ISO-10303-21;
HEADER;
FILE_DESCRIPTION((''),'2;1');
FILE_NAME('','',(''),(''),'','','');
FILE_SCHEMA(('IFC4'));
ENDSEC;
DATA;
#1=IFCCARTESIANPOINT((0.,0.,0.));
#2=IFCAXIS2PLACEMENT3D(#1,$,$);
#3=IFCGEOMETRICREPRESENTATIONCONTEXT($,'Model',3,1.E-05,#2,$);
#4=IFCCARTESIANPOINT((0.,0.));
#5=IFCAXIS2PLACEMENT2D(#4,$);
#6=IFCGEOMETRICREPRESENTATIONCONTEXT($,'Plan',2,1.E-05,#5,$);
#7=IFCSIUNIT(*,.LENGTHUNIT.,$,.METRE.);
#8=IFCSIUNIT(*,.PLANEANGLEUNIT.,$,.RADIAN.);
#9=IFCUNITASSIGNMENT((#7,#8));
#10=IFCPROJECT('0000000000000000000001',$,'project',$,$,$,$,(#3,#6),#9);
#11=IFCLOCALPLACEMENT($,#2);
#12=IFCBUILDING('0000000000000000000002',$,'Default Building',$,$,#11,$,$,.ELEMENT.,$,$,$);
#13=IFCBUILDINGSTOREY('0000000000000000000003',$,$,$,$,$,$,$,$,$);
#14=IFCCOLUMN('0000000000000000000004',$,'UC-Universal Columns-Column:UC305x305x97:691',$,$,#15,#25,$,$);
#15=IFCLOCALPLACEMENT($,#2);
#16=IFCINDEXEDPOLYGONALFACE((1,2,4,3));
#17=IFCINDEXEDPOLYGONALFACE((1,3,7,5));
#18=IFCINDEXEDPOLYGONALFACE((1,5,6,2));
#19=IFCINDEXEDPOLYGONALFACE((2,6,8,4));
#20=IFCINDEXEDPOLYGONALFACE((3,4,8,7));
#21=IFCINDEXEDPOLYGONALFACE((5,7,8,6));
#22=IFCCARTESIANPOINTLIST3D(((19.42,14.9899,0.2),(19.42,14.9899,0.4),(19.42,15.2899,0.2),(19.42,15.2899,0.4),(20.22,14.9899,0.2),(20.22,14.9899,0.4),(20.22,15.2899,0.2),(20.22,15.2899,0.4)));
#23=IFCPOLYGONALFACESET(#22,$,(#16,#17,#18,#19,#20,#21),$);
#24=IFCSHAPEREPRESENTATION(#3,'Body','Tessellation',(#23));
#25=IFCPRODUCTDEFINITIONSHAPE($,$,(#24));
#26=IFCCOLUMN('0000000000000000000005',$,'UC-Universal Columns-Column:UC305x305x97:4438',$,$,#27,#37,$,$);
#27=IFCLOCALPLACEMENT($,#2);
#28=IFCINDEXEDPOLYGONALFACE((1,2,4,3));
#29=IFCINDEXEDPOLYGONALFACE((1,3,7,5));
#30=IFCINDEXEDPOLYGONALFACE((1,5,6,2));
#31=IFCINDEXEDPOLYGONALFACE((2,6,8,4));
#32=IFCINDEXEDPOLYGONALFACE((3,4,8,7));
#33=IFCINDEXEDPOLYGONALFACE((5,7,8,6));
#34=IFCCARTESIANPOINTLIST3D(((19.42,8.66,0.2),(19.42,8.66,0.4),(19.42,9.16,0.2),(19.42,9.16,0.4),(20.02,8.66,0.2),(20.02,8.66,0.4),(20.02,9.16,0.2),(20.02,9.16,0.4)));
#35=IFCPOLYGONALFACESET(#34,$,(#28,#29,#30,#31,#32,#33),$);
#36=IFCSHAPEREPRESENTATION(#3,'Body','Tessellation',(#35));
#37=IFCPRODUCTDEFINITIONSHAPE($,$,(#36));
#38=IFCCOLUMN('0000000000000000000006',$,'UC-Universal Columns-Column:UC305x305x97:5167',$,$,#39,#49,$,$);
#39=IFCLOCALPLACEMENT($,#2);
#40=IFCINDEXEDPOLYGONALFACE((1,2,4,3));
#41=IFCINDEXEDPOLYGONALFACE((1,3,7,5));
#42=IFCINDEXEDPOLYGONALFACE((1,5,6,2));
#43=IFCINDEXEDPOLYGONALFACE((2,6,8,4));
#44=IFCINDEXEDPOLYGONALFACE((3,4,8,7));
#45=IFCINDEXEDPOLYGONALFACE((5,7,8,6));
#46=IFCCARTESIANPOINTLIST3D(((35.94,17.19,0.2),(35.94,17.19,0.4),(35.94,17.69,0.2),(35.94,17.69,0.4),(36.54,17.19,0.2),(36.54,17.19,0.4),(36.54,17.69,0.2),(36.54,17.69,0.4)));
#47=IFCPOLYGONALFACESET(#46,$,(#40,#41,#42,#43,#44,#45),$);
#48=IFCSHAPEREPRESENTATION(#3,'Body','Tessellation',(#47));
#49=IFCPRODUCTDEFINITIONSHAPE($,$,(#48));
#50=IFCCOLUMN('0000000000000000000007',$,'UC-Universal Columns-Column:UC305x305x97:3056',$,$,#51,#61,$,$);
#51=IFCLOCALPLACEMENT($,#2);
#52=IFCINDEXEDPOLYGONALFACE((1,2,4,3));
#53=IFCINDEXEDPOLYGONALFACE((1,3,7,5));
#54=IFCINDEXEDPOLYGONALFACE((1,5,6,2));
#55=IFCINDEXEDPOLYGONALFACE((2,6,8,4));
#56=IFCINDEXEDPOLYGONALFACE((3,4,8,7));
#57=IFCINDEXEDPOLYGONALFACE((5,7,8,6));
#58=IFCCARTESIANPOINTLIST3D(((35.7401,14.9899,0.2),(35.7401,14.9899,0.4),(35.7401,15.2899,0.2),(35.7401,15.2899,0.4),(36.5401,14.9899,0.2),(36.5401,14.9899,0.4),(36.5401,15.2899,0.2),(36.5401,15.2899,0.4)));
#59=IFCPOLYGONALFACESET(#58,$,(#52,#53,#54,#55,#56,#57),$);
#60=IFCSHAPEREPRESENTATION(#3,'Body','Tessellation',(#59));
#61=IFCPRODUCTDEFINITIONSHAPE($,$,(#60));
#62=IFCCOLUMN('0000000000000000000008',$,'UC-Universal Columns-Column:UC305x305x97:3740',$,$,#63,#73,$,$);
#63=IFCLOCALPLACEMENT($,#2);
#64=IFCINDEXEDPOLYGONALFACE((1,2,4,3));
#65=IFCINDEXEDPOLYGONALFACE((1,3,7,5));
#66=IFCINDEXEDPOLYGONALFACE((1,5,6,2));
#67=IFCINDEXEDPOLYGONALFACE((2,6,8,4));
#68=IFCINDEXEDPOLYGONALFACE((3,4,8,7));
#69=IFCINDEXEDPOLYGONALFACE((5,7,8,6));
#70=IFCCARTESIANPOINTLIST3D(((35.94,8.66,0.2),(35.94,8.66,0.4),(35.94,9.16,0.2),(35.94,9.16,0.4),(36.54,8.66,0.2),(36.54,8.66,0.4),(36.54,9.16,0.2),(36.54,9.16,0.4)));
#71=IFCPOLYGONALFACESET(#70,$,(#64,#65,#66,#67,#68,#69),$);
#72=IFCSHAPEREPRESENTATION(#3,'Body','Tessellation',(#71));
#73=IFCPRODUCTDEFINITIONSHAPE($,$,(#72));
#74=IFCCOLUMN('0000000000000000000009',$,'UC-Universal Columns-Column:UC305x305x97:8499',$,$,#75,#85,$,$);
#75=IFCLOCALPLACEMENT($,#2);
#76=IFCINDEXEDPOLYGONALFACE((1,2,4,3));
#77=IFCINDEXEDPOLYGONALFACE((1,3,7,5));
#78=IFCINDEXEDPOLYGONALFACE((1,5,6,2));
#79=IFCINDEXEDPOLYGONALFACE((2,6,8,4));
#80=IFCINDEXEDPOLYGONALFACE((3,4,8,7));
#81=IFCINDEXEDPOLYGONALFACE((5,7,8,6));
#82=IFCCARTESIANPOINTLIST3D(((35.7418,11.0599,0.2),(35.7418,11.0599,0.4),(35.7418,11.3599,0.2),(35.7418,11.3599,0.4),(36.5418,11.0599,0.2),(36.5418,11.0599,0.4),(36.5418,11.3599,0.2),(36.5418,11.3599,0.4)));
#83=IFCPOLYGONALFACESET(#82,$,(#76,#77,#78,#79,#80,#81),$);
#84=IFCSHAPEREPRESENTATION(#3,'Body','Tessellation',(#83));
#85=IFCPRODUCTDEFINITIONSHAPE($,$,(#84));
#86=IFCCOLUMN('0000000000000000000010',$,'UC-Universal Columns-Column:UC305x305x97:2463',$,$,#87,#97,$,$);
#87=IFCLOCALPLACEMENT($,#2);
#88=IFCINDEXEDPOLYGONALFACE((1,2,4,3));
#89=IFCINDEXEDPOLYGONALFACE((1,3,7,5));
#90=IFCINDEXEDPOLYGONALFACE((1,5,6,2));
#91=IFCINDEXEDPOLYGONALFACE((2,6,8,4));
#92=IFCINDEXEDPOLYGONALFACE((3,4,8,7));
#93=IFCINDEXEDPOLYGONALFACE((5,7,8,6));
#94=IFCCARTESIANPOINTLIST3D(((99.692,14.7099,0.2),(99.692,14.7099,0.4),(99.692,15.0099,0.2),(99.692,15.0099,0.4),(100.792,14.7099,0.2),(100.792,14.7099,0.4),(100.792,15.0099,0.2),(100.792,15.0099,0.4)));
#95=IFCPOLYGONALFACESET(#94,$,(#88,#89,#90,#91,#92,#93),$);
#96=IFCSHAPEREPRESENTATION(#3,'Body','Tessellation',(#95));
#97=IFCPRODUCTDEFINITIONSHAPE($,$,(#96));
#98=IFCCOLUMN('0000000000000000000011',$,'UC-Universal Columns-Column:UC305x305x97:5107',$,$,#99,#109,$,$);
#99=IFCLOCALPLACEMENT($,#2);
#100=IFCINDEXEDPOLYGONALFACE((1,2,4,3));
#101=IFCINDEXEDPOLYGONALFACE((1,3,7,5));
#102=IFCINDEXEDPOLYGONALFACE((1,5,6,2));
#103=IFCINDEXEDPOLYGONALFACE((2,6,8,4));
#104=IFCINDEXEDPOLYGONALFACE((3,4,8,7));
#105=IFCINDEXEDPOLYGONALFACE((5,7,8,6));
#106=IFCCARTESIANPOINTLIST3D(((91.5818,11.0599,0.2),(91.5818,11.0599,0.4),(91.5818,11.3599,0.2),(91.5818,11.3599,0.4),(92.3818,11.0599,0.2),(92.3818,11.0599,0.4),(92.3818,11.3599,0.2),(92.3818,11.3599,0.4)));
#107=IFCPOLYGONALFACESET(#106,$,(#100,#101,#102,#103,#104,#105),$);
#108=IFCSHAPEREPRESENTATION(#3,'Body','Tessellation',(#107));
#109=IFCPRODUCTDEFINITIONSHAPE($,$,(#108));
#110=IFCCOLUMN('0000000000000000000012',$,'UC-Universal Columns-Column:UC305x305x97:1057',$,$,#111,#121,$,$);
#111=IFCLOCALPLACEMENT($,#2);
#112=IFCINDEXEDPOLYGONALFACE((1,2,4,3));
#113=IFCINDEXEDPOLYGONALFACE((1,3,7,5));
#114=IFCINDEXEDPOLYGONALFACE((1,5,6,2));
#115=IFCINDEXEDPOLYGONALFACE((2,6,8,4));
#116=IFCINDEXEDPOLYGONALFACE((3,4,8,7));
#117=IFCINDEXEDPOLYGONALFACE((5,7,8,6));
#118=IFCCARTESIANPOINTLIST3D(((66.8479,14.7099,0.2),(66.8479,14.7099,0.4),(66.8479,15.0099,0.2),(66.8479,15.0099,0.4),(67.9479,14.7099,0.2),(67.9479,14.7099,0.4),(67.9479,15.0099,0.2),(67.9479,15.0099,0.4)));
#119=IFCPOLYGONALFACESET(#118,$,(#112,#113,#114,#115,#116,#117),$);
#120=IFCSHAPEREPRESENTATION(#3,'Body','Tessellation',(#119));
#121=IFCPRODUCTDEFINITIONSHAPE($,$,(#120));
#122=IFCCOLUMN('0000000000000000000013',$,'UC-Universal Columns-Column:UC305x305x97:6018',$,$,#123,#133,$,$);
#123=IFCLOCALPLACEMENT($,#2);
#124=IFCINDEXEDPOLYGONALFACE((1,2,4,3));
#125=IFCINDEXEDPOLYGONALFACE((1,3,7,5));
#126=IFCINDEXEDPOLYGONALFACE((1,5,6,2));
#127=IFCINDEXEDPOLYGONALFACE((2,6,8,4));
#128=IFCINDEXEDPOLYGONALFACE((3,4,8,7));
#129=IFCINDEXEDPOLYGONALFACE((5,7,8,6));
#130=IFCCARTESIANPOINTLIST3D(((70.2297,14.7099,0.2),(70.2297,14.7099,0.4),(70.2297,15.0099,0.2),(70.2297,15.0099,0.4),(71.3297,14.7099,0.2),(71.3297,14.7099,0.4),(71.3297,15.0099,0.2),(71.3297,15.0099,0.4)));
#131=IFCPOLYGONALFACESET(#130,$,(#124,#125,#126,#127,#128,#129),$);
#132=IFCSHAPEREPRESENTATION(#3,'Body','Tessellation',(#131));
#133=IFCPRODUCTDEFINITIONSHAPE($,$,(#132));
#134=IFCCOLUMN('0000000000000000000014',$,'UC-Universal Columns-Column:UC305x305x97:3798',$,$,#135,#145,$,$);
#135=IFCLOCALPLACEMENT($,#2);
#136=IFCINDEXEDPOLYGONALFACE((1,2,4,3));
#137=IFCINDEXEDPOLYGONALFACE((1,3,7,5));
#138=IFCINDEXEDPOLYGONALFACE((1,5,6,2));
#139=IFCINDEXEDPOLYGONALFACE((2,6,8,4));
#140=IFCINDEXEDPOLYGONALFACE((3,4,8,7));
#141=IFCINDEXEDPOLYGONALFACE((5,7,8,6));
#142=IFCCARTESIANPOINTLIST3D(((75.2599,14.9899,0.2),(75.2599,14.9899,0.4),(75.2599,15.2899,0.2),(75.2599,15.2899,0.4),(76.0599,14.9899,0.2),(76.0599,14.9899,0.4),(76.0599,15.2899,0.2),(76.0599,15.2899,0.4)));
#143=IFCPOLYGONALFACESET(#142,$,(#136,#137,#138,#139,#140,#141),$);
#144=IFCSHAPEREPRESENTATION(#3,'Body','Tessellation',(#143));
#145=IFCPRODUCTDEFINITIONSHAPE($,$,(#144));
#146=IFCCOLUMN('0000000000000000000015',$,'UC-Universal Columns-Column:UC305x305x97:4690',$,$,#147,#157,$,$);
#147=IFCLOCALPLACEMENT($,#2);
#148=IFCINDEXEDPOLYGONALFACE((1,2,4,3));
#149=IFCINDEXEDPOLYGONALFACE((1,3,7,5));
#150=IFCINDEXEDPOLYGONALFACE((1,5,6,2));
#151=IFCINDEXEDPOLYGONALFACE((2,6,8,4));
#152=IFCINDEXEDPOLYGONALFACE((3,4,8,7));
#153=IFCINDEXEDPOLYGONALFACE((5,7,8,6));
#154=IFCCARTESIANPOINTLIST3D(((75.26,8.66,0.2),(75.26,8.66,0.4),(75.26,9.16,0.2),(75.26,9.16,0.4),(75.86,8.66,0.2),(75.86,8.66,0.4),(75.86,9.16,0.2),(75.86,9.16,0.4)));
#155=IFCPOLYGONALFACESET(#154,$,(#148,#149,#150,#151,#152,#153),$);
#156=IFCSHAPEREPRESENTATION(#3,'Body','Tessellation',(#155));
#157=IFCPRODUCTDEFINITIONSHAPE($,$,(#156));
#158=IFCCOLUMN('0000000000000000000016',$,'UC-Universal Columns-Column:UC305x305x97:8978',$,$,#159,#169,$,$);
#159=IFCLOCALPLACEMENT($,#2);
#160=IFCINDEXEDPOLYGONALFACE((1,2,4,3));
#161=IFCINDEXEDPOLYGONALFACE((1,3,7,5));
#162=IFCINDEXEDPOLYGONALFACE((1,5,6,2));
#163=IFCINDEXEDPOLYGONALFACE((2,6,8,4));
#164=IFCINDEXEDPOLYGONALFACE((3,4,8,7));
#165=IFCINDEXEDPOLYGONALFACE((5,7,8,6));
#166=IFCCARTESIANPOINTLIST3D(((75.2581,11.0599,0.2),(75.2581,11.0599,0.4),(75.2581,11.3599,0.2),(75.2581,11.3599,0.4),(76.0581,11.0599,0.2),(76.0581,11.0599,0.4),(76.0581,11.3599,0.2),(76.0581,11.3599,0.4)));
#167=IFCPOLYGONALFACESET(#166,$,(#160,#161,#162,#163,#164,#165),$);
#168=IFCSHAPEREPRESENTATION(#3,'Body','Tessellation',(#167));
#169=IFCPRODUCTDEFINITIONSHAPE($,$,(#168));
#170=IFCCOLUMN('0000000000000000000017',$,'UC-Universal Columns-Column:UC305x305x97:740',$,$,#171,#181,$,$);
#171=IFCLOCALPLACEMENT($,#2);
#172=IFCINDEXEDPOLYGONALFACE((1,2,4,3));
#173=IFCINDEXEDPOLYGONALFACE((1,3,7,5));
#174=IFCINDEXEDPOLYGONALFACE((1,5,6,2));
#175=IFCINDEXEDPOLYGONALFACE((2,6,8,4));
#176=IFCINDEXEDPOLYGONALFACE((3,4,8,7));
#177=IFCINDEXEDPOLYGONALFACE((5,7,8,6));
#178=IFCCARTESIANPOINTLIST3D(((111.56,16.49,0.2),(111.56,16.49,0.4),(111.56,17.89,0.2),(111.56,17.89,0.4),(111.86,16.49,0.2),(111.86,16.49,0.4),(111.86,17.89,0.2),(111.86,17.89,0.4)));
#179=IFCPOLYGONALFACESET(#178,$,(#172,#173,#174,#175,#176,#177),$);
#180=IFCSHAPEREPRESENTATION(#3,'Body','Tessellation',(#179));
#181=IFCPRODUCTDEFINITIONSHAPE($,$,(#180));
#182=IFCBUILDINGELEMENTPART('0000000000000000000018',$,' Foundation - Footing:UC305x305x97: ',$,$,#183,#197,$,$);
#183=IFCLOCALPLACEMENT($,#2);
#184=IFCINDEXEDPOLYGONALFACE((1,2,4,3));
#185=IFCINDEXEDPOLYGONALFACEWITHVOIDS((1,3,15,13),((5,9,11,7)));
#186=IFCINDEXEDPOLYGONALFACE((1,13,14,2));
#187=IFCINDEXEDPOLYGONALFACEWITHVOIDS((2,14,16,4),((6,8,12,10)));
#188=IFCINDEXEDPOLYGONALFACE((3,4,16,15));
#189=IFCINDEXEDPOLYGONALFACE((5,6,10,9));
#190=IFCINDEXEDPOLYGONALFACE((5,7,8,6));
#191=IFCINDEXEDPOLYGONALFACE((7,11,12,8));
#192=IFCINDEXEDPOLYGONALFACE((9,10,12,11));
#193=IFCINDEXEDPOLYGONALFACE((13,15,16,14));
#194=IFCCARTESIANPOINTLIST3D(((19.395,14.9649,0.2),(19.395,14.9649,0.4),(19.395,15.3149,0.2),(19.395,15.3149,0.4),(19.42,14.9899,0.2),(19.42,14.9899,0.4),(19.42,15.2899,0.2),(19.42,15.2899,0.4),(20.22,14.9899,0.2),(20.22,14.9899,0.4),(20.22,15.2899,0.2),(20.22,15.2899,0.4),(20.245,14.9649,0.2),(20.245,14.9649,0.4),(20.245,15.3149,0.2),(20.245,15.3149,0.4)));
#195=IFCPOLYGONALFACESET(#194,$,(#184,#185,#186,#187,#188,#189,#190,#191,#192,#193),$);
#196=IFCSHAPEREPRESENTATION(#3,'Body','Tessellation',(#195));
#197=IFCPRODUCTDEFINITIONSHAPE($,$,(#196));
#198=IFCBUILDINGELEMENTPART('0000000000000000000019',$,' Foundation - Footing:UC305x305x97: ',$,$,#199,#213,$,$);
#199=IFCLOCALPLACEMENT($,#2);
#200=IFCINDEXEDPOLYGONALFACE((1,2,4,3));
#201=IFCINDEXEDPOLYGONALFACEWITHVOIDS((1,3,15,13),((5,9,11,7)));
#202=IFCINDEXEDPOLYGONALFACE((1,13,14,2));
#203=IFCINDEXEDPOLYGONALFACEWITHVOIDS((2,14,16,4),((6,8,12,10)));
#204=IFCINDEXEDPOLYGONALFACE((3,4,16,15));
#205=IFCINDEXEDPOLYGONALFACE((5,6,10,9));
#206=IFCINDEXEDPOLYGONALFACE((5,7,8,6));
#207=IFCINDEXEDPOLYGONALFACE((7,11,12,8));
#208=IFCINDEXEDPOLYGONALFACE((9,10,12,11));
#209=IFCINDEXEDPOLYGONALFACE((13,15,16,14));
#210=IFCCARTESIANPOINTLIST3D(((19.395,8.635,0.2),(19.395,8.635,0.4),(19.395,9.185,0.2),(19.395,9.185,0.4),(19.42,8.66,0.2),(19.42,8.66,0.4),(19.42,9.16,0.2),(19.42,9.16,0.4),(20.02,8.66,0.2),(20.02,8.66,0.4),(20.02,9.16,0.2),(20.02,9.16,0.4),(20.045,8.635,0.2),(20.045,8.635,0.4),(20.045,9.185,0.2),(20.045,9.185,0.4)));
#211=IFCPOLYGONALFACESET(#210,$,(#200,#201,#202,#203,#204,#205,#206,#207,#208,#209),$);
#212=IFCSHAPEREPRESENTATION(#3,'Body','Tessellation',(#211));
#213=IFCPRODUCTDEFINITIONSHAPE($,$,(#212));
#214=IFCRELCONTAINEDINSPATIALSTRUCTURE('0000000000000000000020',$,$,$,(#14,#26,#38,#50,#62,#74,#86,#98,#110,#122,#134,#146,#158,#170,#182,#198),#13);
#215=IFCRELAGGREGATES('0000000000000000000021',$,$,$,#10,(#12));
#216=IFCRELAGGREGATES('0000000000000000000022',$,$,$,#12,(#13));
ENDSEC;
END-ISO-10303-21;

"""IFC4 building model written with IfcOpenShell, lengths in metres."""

from ifc_helpers import new_model, si_unit, origin, origin_2d, place, context, project, spatial, polyline, outline, extrude, element, save


model = new_model("IFC4")

# Units and contexts
model_context = context("Model", 3, precision=1e-05, world=origin())
plan_context = context("Plan", 2, precision=1e-05, world=origin_2d())
ifc_project = project(units=[si_unit("LENGTHUNIT", "METRE"), si_unit("PLANEANGLEUNIT", "RADIAN")], contexts=[model_context, plan_context])

# Building, storey
building_placement = place(None, origin())
building = spatial("IfcBuilding", under=ifc_project, at=building_placement, Name="Default Building", CompositionType="ELEMENT")
storey = spatial("IfcBuildingStorey", under=building)

# Columns
element("IfcColumn", 1, inside=storey, Name="UC-Universal Columns-Column:UC305x305x97:691", context=model_context, shape_type="SweptSolid", body=[
    extrude(outline(polyline([(19.42, 15.2899, 0.2), (20.22, 15.2899, 0.2), (20.22, 14.9899, 0.2), (19.42, 14.9899, 0.2), (19.42, 15.2899, 0.2)])), None, (0.0, 0.0, 1.0), 0.2),
])
element("IfcColumn", 2, inside=storey, Name="UC-Universal Columns-Column:UC305x305x97:4438", context=model_context, shape_type="SweptSolid", body=[
    extrude(outline(polyline([(19.42, 8.66, 0.2), (20.02, 8.66, 0.2), (20.02, 9.16, 0.2), (19.42, 9.16, 0.2), (19.42, 8.66, 0.2)])), None, (0.0, 0.0, 1.0), 0.2),
])
element("IfcColumn", 3, inside=storey, Name="UC-Universal Columns-Column:UC305x305x97:5167", context=model_context, shape_type="SweptSolid", body=[
    extrude(outline(polyline([(36.54, 17.69, 0.2), (35.94, 17.69, 0.2), (35.94, 17.19, 0.2), (36.54, 17.19, 0.2), (36.54, 17.69, 0.2)])), None, (0.0, 0.0, 1.0), 0.2),
])
element("IfcColumn", 4, inside=storey, Name="UC-Universal Columns-Column:UC305x305x97:3056", context=model_context, shape_type="SweptSolid", body=[
    extrude(outline(polyline([(36.5401, 15.2899, 0.2), (35.7401, 15.2899, 0.2), (35.7401, 14.9899, 0.2), (36.5401, 14.9899, 0.2), (36.5401, 15.2899, 0.2)])), None, (0.0, 0.0, 1.0), 0.2),
])
element("IfcColumn", 5, inside=storey, Name="UC-Universal Columns-Column:UC305x305x97:3740", context=model_context, shape_type="SweptSolid", body=[
    extrude(outline(polyline([(36.54, 8.66, 0.2), (35.94, 8.66, 0.2), (35.94, 9.16, 0.2), (36.54, 9.16, 0.2), (36.54, 8.66, 0.2)])), None, (0.0, 0.0, 1.0), 0.2),
])
element("IfcColumn", 6, inside=storey, Name="UC-Universal Columns-Column:UC305x305x97:8499", context=model_context, shape_type="SweptSolid", body=[
    extrude(outline(polyline([(36.5418, 11.0599, 0.2), (35.7418, 11.0599, 0.2), (35.7418, 11.3599, 0.2), (36.5418, 11.3599, 0.2), (36.5418, 11.0599, 0.2)])), None, (0.0, 0.0, 1.0), 0.2),
])
element("IfcColumn", 7, inside=storey, Name="UC-Universal Columns-Column:UC305x305x97:2463", context=model_context, shape_type="SweptSolid", body=[
    extrude(outline(polyline([(100.792, 14.7099, 0.2), (100.792, 15.0099, 0.2), (99.692, 15.0099, 0.2), (99.692, 14.7099, 0.2), (100.792, 14.7099, 0.2)])), None, (0.0, 0.0, 1.0), 0.2),
])
element("IfcColumn", 8, inside=storey, Name="UC-Universal Columns-Column:UC305x305x97:5107", context=model_context, shape_type="SweptSolid", body=[
    extrude(outline(polyline([(92.3818, 11.0599, 0.2), (91.5818, 11.0599, 0.2), (91.5818, 11.3599, 0.2), (92.3818, 11.3599, 0.2), (92.3818, 11.0599, 0.2)])), None, (0.0, 0.0, 1.0), 0.2),
])
element("IfcColumn", 9, inside=storey, Name="UC-Universal Columns-Column:UC305x305x97:1057", context=model_context, shape_type="SweptSolid", body=[
    extrude(outline(polyline([(66.8479, 14.7099, 0.2), (66.8479, 15.0099, 0.2), (67.9479, 15.0099, 0.2), (67.9479, 14.7099, 0.2), (66.8479, 14.7099, 0.2)])), None, (0.0, 0.0, 1.0), 0.2),
])
element("IfcColumn", 10, inside=storey, Name="UC-Universal Columns-Column:UC305x305x97:6018", context=model_context, shape_type="SweptSolid", body=[
    extrude(outline(polyline([(70.2297, 15.0099, 0.2), (71.3297, 15.0099, 0.2), (71.3297, 14.7099, 0.2), (70.2297, 14.7099, 0.2), (70.2297, 15.0099, 0.2)])), None, (0.0, 0.0, 1.0), 0.2),
])
element("IfcColumn", 11, inside=storey, Name="UC-Universal Columns-Column:UC305x305x97:3798", context=model_context, shape_type="SweptSolid", body=[
    extrude(outline(polyline([(75.2599, 15.2899, 0.2), (76.0599, 15.2899, 0.2), (76.0599, 14.9899, 0.2), (75.2599, 14.9899, 0.2), (75.2599, 15.2899, 0.2)])), None, (0.0, 0.0, 1.0), 0.2),
])
element("IfcColumn", 12, inside=storey, Name="UC-Universal Columns-Column:UC305x305x97:4690", context=model_context, shape_type="SweptSolid", body=[
    extrude(outline(polyline([(75.26, 8.66, 0.2), (75.86, 8.66, 0.2), (75.86, 9.16, 0.2), (75.26, 9.16, 0.2), (75.26, 8.66, 0.2)])), None, (0.0, 0.0, 1.0), 0.2),
])
element("IfcColumn", 13, inside=storey, Name="UC-Universal Columns-Column:UC305x305x97:8978", context=model_context, shape_type="SweptSolid", body=[
    extrude(outline(polyline([(75.2581, 11.0599, 0.2), (76.0581, 11.0599, 0.2), (76.0581, 11.3599, 0.2), (75.2581, 11.3599, 0.2), (75.2581, 11.0599, 0.2)])), None, (0.0, 0.0, 1.0), 0.2),
])
element("IfcColumn", 14, inside=storey, Name="UC-Universal Columns-Column:UC305x305x97:740", context=model_context, shape_type="SweptSolid", body=[
    extrude(outline(polyline([(111.86, 17.89, 0.2), (111.56, 17.89, 0.2), (111.56, 16.49, 0.2), (111.86, 16.49, 0.2), (111.86, 17.89, 0.2)])), None, (0.0, 0.0, 1.0), 0.2),
])

# Building element parts, openings
building_element_part_1 = element("IfcBuildingElementPart", 15, inside=storey, Name=" Foundation - Footing:UC305x305x97: ", context=model_context, shape_type="SweptSolid", body=[
    extrude(outline(polyline([(19.395, 15.3149, 0.2), (20.245, 15.3149, 0.2), (20.245, 14.9649, 0.2), (19.395, 14.9649, 0.2), (19.395, 15.3149, 0.2)])), None, (0.0, 0.0, 1.0), 0.2),
])
element("IfcOpeningElement", 16, inside=storey, cuts=building_element_part_1, context=model_context, shape_type="SweptSolid", body=[
    extrude(outline(polyline([(19.42, 15.2899, 0.2), (20.22, 15.2899, 0.2), (20.22, 14.9899, 0.2), (19.42, 14.9899, 0.2), (19.42, 15.2899, 0.2)])), None, (0.0, 0.0, 1.0), 0.2),
])
building_element_part_2 = element("IfcBuildingElementPart", 17, inside=storey, Name=" Foundation - Footing:UC305x305x97: ", context=model_context, shape_type="SweptSolid", body=[
    extrude(outline(polyline([(19.395, 8.635, 0.2), (20.045, 8.635, 0.2), (20.045, 9.185, 0.2), (19.395, 9.185, 0.2), (19.395, 8.635, 0.2)])), None, (0.0, 0.0, 1.0), 0.2),
])
element("IfcOpeningElement", 18, inside=storey, cuts=building_element_part_2, context=model_context, shape_type="SweptSolid", body=[
    extrude(outline(polyline([(19.42, 8.66, 0.2), (20.02, 8.66, 0.2), (20.02, 9.16, 0.2), (19.42, 9.16, 0.2), (19.42, 8.66, 0.2)])), None, (0.0, 0.0, 1.0), 0.2),
])

save(model, "model.ifc")
